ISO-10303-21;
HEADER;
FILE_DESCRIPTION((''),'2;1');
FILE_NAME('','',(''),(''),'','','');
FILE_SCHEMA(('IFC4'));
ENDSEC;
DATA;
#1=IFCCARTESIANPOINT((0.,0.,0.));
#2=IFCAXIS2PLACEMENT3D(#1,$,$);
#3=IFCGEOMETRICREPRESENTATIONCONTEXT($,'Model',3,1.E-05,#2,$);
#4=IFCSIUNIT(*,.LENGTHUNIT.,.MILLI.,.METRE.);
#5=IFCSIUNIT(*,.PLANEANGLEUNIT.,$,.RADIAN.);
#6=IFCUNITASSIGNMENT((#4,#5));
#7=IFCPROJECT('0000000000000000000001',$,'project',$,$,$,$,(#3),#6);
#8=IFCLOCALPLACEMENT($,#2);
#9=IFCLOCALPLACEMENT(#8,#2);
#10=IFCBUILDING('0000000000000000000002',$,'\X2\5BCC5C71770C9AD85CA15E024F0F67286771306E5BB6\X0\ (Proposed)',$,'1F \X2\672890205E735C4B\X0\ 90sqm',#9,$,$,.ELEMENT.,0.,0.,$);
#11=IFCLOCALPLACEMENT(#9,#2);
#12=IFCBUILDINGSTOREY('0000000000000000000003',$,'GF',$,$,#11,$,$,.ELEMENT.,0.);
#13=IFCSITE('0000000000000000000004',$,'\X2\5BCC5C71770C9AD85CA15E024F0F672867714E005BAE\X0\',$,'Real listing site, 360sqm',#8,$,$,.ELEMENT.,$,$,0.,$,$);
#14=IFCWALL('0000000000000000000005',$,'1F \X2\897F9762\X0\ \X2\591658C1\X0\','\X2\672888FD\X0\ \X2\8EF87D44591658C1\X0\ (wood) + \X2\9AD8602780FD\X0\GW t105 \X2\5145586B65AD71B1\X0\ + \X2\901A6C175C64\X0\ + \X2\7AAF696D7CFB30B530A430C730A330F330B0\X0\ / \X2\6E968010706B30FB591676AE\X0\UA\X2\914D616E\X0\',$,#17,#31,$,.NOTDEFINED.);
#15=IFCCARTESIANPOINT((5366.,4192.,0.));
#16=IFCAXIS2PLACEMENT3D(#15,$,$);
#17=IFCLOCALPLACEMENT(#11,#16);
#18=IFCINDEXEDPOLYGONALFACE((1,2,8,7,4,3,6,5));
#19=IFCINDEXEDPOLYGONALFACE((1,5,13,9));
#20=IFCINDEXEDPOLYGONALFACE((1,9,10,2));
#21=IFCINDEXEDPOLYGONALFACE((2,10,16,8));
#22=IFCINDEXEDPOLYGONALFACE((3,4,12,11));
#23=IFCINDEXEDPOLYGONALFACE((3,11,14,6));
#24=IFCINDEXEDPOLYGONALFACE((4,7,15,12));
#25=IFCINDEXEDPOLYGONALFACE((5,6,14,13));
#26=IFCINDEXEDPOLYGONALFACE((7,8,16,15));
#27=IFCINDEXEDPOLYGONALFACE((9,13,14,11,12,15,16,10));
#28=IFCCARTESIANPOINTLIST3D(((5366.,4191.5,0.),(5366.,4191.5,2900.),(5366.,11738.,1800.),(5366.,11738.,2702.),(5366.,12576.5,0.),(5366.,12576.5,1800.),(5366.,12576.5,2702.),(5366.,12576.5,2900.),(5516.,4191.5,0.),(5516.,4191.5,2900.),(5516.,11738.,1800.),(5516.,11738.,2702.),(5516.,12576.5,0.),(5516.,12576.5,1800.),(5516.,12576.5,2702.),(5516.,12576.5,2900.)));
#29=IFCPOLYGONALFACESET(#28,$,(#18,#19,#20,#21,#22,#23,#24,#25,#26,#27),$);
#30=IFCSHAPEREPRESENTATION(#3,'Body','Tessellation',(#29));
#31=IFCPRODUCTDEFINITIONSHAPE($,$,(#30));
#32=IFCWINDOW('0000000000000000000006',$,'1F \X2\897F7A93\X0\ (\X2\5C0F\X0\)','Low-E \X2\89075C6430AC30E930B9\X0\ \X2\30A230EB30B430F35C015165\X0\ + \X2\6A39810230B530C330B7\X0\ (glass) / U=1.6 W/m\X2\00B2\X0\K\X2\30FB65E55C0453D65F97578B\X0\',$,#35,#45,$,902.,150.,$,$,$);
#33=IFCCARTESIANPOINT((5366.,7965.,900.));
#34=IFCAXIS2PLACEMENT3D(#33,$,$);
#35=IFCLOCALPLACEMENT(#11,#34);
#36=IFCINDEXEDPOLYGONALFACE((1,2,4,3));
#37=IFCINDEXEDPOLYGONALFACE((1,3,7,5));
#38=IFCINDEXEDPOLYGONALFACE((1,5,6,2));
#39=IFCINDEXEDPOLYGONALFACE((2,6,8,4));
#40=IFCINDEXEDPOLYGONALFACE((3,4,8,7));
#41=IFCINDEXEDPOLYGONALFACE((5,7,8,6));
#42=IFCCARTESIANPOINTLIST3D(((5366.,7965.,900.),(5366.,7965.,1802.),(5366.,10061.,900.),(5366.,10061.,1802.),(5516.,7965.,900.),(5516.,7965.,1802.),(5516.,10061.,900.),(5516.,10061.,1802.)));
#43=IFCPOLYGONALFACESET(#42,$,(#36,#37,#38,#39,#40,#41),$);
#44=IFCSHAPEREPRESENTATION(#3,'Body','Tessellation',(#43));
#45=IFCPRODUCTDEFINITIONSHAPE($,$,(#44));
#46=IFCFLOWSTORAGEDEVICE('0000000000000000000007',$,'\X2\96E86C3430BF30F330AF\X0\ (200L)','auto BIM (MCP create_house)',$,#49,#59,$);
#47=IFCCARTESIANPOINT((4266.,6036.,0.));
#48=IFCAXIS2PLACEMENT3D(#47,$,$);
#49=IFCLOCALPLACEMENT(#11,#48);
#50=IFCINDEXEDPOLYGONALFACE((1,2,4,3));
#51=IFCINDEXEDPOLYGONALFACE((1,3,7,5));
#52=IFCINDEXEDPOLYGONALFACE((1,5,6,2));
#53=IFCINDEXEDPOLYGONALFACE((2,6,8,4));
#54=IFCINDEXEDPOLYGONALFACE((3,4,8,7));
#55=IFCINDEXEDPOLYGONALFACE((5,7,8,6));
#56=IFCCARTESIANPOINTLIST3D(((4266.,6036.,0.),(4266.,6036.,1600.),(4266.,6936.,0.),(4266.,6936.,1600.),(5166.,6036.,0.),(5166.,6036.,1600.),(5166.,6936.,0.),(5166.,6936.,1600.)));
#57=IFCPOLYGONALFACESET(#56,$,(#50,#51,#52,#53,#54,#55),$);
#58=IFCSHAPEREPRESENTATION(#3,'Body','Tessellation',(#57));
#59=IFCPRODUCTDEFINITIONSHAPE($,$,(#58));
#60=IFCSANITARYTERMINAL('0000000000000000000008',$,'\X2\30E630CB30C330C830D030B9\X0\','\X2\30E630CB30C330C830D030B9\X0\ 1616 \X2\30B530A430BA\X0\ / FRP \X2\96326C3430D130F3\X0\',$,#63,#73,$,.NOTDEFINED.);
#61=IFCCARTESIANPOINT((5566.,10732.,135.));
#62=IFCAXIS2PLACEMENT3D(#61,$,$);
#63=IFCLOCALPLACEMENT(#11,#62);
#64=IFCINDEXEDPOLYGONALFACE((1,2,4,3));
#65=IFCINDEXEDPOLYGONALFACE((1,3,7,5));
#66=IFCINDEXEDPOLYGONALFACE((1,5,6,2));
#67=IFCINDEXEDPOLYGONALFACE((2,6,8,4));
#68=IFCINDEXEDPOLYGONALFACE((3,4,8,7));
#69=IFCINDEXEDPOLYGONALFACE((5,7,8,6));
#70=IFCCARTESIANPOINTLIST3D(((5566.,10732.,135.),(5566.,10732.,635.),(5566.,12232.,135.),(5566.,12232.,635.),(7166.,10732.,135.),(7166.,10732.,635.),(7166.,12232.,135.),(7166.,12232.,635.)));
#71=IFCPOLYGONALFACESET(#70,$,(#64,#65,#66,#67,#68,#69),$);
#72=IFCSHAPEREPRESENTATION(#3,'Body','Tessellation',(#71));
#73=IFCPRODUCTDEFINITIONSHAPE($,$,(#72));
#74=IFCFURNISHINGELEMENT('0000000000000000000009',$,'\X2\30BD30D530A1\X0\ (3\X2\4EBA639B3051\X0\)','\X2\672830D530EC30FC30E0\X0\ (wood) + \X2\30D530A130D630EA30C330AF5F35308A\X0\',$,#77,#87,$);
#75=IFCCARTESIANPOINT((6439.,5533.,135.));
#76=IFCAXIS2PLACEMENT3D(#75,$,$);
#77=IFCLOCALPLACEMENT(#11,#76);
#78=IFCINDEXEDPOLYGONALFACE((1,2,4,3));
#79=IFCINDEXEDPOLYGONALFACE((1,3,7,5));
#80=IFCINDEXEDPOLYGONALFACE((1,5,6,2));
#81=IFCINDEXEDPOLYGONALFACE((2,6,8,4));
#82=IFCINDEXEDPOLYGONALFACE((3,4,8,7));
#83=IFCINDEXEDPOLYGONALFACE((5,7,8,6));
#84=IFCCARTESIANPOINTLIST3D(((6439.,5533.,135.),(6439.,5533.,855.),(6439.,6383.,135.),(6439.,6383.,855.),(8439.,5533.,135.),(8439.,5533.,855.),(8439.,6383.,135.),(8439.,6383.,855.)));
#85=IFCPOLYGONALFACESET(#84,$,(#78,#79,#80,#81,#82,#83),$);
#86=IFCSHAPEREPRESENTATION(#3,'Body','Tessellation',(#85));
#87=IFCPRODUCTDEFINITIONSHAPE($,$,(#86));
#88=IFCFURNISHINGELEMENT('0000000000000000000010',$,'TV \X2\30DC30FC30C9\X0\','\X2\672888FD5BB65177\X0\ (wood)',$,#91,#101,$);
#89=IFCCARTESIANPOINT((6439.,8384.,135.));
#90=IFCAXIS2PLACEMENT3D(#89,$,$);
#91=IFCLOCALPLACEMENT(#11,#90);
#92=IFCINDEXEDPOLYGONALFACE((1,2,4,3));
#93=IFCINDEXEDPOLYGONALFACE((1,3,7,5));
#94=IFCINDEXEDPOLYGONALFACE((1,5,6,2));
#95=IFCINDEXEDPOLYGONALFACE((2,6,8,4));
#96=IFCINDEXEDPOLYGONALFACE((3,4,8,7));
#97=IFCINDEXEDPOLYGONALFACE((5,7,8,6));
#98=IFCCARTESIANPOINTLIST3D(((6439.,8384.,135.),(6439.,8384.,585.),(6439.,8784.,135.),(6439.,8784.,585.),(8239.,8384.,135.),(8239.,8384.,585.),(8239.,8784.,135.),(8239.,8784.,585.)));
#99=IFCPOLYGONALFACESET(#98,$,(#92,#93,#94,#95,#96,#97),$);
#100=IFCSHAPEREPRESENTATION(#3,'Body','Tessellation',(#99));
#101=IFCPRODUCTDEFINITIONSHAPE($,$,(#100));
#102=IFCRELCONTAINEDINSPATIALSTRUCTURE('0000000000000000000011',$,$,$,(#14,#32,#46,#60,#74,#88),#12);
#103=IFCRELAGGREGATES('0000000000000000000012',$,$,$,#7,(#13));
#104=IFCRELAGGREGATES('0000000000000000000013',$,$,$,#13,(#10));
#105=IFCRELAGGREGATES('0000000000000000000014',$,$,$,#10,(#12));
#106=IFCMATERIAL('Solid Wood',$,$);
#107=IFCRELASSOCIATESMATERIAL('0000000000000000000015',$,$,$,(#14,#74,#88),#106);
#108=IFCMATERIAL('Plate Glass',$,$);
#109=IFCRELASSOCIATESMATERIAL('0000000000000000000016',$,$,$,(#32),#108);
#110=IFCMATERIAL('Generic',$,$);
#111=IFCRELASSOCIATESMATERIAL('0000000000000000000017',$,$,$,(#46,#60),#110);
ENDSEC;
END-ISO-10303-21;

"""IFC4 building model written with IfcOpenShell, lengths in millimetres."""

from ifc_helpers import new_model, si_unit, frame, frame_2d, origin, place, context, project, spatial, rectangle, extrude, material, element, fill, save


model = new_model("IFC4")

# Units and contexts
model_context = context("Model", 3, precision=1e-05, world=origin())
ifc_project = project(units=[si_unit("LENGTHUNIT", "METRE", prefix="MILLI"), si_unit("PLANEANGLEUNIT", "RADIAN")], contexts=[model_context])

# Site, building, storey
site_placement = place(None, origin())
site = spatial("IfcSite", under=ifc_project, at=site_placement, Name="富山県高岡市伏木東一宮", ObjectType="Real listing site, 360sqm", CompositionType="ELEMENT", RefElevation=0.0)
building_placement = place(site_placement, origin())
building = spatial("IfcBuilding", under=site, at=building_placement, Name="富山県高岡市伏木東の家 (Proposed)", ObjectType="1F 木造平屋 90sqm", CompositionType="ELEMENT", ElevationOfRefHeight=0.0, ElevationOfTerrain=0.0)
storey_placement = place(building_placement, origin())
storey = spatial("IfcBuildingStorey", under=building, at=storey_placement, Name="GF", CompositionType="ELEMENT", Elevation=0.0)

# Shared definitions
ifc_material_1 = material(Name="Solid Wood")

# Shared definitions
ifc_material_2 = material(Name="Plate Glass")

# Wall, opening, window
wall_1_placement = place(storey_placement, frame((5366.0, 4192.0, 0.0)))
wall_1 = element("IfcWall", 1, at=wall_1_placement, inside=storey, material=ifc_material_1, Name="1F 西面 外壁", Description="木製 軸組外壁 (wood) + 高性能GW t105 充填断熱 + 通気層 + 窯業系サイディング / 準耐火・外皮UA配慮", PredefinedType="NOTDEFINED", context=model_context, shape_type="SweptSolid", body=[
    extrude(rectangle(XDim=150.0, YDim=8385.0, at=frame_2d((75.0, 4192.0))), frame((5366.0, 4192.0, 0.0)), (0.0, 0.0, 1.0), 2900.0),
])
opening_1_placement = place(storey_placement, frame((5366.0, 7965.0, 900.0)))
opening_1 = element("IfcOpeningElement", 2, at=opening_1_placement, cuts=wall_1, PredefinedType="NOTDEFINED", context=model_context, shape_type="SweptSolid", body=[
    extrude(rectangle(XDim=150.0, YDim=2096.0, at=frame_2d((75.0, 1048.0))), frame((5366.0, 7965.0, 900.0)), (0.0, 0.0, 1.0), 902.0),
])
window_1_placement = place(storey_placement, frame((5366.0, 7965.0, 900.0)))
window_1 = element("IfcWindow", 3, at=window_1_placement, inside=storey, material=ifc_material_2, Name="1F 西窓 (小)", Description="Low-E 複層ガラス アルゴン封入 + 樹脂サッシ (glass) / U=1.6 W/m²K・日射取得型", OverallHeight=902.0, OverallWidth=150.0, context=model_context, shape_type="SweptSolid", body=[
    extrude(rectangle(XDim=150.0, YDim=2096.0, at=frame_2d((75.0, 1048.0))), frame((5366.0, 7965.0, 900.0)), (0.0, 0.0, 1.0), 902.0),
])
fill(opening_1, window_1)

# Shared definitions
ifc_material_3 = material(Name="Generic")

# Flow storage device
flow_storage_device_placement = place(storey_placement, frame((4266.0, 6036.0, 0.0)))
element("IfcFlowStorageDevice", 4, at=flow_storage_device_placement, inside=storey, material=ifc_material_3, Name="雨水タンク (200L)", Description="auto BIM (MCP create_house)", context=model_context, shape_type="SweptSolid", body=[
    extrude(rectangle(XDim=900.0, YDim=900.0, at=frame_2d((450.0, 450.0))), frame((4266.0, 6036.0, 0.0)), (0.0, 0.0, 1.0), 1600.0),
])

# Sanitary terminal
sanitary_terminal_placement = place(storey_placement, frame((5566.0, 10732.0, 135.0)))
element("IfcSanitaryTerminal", 5, at=sanitary_terminal_placement, inside=storey, material=ifc_material_3, Name="ユニットバス", Description="ユニットバス 1616 サイズ / FRP 防水パン", PredefinedType="NOTDEFINED", context=model_context, shape_type="SweptSolid", body=[
    extrude(rectangle(XDim=1600.0, YDim=1500.0, at=frame_2d((800.0, 750.0))), frame((5566.0, 10732.0, 135.0)), (0.0, 0.0, 1.0), 500.0),
])

# Furnishing elements
furnishing_1_placement = place(storey_placement, frame((6439.0, 5533.0, 135.0)))
element("IfcFurnishingElement", 6, at=furnishing_1_placement, inside=storey, material=ifc_material_1, Name="ソファ (3人掛け)", Description="木フレーム (wood) + ファブリック張り", context=model_context, shape_type="SweptSolid", body=[
    extrude(rectangle(XDim=2000.0, YDim=850.0, at=frame_2d((1000.0, 425.0))), frame((6439.0, 5533.0, 135.0)), (0.0, 0.0, 1.0), 720.0),
])
furnishing_2_placement = place(storey_placement, frame((6439.0, 8384.0, 135.0)))
element("IfcFurnishingElement", 7, at=furnishing_2_placement, inside=storey, material=ifc_material_1, Name="TV ボード", Description="木製家具 (wood)", context=model_context, shape_type="SweptSolid", body=[
    extrude(rectangle(XDim=1800.0, YDim=400.0, at=frame_2d((900.0, 200.0))), frame((6439.0, 8384.0, 135.0)), (0.0, 0.0, 1.0), 450.0),
])

save(model, "model.ifc")
